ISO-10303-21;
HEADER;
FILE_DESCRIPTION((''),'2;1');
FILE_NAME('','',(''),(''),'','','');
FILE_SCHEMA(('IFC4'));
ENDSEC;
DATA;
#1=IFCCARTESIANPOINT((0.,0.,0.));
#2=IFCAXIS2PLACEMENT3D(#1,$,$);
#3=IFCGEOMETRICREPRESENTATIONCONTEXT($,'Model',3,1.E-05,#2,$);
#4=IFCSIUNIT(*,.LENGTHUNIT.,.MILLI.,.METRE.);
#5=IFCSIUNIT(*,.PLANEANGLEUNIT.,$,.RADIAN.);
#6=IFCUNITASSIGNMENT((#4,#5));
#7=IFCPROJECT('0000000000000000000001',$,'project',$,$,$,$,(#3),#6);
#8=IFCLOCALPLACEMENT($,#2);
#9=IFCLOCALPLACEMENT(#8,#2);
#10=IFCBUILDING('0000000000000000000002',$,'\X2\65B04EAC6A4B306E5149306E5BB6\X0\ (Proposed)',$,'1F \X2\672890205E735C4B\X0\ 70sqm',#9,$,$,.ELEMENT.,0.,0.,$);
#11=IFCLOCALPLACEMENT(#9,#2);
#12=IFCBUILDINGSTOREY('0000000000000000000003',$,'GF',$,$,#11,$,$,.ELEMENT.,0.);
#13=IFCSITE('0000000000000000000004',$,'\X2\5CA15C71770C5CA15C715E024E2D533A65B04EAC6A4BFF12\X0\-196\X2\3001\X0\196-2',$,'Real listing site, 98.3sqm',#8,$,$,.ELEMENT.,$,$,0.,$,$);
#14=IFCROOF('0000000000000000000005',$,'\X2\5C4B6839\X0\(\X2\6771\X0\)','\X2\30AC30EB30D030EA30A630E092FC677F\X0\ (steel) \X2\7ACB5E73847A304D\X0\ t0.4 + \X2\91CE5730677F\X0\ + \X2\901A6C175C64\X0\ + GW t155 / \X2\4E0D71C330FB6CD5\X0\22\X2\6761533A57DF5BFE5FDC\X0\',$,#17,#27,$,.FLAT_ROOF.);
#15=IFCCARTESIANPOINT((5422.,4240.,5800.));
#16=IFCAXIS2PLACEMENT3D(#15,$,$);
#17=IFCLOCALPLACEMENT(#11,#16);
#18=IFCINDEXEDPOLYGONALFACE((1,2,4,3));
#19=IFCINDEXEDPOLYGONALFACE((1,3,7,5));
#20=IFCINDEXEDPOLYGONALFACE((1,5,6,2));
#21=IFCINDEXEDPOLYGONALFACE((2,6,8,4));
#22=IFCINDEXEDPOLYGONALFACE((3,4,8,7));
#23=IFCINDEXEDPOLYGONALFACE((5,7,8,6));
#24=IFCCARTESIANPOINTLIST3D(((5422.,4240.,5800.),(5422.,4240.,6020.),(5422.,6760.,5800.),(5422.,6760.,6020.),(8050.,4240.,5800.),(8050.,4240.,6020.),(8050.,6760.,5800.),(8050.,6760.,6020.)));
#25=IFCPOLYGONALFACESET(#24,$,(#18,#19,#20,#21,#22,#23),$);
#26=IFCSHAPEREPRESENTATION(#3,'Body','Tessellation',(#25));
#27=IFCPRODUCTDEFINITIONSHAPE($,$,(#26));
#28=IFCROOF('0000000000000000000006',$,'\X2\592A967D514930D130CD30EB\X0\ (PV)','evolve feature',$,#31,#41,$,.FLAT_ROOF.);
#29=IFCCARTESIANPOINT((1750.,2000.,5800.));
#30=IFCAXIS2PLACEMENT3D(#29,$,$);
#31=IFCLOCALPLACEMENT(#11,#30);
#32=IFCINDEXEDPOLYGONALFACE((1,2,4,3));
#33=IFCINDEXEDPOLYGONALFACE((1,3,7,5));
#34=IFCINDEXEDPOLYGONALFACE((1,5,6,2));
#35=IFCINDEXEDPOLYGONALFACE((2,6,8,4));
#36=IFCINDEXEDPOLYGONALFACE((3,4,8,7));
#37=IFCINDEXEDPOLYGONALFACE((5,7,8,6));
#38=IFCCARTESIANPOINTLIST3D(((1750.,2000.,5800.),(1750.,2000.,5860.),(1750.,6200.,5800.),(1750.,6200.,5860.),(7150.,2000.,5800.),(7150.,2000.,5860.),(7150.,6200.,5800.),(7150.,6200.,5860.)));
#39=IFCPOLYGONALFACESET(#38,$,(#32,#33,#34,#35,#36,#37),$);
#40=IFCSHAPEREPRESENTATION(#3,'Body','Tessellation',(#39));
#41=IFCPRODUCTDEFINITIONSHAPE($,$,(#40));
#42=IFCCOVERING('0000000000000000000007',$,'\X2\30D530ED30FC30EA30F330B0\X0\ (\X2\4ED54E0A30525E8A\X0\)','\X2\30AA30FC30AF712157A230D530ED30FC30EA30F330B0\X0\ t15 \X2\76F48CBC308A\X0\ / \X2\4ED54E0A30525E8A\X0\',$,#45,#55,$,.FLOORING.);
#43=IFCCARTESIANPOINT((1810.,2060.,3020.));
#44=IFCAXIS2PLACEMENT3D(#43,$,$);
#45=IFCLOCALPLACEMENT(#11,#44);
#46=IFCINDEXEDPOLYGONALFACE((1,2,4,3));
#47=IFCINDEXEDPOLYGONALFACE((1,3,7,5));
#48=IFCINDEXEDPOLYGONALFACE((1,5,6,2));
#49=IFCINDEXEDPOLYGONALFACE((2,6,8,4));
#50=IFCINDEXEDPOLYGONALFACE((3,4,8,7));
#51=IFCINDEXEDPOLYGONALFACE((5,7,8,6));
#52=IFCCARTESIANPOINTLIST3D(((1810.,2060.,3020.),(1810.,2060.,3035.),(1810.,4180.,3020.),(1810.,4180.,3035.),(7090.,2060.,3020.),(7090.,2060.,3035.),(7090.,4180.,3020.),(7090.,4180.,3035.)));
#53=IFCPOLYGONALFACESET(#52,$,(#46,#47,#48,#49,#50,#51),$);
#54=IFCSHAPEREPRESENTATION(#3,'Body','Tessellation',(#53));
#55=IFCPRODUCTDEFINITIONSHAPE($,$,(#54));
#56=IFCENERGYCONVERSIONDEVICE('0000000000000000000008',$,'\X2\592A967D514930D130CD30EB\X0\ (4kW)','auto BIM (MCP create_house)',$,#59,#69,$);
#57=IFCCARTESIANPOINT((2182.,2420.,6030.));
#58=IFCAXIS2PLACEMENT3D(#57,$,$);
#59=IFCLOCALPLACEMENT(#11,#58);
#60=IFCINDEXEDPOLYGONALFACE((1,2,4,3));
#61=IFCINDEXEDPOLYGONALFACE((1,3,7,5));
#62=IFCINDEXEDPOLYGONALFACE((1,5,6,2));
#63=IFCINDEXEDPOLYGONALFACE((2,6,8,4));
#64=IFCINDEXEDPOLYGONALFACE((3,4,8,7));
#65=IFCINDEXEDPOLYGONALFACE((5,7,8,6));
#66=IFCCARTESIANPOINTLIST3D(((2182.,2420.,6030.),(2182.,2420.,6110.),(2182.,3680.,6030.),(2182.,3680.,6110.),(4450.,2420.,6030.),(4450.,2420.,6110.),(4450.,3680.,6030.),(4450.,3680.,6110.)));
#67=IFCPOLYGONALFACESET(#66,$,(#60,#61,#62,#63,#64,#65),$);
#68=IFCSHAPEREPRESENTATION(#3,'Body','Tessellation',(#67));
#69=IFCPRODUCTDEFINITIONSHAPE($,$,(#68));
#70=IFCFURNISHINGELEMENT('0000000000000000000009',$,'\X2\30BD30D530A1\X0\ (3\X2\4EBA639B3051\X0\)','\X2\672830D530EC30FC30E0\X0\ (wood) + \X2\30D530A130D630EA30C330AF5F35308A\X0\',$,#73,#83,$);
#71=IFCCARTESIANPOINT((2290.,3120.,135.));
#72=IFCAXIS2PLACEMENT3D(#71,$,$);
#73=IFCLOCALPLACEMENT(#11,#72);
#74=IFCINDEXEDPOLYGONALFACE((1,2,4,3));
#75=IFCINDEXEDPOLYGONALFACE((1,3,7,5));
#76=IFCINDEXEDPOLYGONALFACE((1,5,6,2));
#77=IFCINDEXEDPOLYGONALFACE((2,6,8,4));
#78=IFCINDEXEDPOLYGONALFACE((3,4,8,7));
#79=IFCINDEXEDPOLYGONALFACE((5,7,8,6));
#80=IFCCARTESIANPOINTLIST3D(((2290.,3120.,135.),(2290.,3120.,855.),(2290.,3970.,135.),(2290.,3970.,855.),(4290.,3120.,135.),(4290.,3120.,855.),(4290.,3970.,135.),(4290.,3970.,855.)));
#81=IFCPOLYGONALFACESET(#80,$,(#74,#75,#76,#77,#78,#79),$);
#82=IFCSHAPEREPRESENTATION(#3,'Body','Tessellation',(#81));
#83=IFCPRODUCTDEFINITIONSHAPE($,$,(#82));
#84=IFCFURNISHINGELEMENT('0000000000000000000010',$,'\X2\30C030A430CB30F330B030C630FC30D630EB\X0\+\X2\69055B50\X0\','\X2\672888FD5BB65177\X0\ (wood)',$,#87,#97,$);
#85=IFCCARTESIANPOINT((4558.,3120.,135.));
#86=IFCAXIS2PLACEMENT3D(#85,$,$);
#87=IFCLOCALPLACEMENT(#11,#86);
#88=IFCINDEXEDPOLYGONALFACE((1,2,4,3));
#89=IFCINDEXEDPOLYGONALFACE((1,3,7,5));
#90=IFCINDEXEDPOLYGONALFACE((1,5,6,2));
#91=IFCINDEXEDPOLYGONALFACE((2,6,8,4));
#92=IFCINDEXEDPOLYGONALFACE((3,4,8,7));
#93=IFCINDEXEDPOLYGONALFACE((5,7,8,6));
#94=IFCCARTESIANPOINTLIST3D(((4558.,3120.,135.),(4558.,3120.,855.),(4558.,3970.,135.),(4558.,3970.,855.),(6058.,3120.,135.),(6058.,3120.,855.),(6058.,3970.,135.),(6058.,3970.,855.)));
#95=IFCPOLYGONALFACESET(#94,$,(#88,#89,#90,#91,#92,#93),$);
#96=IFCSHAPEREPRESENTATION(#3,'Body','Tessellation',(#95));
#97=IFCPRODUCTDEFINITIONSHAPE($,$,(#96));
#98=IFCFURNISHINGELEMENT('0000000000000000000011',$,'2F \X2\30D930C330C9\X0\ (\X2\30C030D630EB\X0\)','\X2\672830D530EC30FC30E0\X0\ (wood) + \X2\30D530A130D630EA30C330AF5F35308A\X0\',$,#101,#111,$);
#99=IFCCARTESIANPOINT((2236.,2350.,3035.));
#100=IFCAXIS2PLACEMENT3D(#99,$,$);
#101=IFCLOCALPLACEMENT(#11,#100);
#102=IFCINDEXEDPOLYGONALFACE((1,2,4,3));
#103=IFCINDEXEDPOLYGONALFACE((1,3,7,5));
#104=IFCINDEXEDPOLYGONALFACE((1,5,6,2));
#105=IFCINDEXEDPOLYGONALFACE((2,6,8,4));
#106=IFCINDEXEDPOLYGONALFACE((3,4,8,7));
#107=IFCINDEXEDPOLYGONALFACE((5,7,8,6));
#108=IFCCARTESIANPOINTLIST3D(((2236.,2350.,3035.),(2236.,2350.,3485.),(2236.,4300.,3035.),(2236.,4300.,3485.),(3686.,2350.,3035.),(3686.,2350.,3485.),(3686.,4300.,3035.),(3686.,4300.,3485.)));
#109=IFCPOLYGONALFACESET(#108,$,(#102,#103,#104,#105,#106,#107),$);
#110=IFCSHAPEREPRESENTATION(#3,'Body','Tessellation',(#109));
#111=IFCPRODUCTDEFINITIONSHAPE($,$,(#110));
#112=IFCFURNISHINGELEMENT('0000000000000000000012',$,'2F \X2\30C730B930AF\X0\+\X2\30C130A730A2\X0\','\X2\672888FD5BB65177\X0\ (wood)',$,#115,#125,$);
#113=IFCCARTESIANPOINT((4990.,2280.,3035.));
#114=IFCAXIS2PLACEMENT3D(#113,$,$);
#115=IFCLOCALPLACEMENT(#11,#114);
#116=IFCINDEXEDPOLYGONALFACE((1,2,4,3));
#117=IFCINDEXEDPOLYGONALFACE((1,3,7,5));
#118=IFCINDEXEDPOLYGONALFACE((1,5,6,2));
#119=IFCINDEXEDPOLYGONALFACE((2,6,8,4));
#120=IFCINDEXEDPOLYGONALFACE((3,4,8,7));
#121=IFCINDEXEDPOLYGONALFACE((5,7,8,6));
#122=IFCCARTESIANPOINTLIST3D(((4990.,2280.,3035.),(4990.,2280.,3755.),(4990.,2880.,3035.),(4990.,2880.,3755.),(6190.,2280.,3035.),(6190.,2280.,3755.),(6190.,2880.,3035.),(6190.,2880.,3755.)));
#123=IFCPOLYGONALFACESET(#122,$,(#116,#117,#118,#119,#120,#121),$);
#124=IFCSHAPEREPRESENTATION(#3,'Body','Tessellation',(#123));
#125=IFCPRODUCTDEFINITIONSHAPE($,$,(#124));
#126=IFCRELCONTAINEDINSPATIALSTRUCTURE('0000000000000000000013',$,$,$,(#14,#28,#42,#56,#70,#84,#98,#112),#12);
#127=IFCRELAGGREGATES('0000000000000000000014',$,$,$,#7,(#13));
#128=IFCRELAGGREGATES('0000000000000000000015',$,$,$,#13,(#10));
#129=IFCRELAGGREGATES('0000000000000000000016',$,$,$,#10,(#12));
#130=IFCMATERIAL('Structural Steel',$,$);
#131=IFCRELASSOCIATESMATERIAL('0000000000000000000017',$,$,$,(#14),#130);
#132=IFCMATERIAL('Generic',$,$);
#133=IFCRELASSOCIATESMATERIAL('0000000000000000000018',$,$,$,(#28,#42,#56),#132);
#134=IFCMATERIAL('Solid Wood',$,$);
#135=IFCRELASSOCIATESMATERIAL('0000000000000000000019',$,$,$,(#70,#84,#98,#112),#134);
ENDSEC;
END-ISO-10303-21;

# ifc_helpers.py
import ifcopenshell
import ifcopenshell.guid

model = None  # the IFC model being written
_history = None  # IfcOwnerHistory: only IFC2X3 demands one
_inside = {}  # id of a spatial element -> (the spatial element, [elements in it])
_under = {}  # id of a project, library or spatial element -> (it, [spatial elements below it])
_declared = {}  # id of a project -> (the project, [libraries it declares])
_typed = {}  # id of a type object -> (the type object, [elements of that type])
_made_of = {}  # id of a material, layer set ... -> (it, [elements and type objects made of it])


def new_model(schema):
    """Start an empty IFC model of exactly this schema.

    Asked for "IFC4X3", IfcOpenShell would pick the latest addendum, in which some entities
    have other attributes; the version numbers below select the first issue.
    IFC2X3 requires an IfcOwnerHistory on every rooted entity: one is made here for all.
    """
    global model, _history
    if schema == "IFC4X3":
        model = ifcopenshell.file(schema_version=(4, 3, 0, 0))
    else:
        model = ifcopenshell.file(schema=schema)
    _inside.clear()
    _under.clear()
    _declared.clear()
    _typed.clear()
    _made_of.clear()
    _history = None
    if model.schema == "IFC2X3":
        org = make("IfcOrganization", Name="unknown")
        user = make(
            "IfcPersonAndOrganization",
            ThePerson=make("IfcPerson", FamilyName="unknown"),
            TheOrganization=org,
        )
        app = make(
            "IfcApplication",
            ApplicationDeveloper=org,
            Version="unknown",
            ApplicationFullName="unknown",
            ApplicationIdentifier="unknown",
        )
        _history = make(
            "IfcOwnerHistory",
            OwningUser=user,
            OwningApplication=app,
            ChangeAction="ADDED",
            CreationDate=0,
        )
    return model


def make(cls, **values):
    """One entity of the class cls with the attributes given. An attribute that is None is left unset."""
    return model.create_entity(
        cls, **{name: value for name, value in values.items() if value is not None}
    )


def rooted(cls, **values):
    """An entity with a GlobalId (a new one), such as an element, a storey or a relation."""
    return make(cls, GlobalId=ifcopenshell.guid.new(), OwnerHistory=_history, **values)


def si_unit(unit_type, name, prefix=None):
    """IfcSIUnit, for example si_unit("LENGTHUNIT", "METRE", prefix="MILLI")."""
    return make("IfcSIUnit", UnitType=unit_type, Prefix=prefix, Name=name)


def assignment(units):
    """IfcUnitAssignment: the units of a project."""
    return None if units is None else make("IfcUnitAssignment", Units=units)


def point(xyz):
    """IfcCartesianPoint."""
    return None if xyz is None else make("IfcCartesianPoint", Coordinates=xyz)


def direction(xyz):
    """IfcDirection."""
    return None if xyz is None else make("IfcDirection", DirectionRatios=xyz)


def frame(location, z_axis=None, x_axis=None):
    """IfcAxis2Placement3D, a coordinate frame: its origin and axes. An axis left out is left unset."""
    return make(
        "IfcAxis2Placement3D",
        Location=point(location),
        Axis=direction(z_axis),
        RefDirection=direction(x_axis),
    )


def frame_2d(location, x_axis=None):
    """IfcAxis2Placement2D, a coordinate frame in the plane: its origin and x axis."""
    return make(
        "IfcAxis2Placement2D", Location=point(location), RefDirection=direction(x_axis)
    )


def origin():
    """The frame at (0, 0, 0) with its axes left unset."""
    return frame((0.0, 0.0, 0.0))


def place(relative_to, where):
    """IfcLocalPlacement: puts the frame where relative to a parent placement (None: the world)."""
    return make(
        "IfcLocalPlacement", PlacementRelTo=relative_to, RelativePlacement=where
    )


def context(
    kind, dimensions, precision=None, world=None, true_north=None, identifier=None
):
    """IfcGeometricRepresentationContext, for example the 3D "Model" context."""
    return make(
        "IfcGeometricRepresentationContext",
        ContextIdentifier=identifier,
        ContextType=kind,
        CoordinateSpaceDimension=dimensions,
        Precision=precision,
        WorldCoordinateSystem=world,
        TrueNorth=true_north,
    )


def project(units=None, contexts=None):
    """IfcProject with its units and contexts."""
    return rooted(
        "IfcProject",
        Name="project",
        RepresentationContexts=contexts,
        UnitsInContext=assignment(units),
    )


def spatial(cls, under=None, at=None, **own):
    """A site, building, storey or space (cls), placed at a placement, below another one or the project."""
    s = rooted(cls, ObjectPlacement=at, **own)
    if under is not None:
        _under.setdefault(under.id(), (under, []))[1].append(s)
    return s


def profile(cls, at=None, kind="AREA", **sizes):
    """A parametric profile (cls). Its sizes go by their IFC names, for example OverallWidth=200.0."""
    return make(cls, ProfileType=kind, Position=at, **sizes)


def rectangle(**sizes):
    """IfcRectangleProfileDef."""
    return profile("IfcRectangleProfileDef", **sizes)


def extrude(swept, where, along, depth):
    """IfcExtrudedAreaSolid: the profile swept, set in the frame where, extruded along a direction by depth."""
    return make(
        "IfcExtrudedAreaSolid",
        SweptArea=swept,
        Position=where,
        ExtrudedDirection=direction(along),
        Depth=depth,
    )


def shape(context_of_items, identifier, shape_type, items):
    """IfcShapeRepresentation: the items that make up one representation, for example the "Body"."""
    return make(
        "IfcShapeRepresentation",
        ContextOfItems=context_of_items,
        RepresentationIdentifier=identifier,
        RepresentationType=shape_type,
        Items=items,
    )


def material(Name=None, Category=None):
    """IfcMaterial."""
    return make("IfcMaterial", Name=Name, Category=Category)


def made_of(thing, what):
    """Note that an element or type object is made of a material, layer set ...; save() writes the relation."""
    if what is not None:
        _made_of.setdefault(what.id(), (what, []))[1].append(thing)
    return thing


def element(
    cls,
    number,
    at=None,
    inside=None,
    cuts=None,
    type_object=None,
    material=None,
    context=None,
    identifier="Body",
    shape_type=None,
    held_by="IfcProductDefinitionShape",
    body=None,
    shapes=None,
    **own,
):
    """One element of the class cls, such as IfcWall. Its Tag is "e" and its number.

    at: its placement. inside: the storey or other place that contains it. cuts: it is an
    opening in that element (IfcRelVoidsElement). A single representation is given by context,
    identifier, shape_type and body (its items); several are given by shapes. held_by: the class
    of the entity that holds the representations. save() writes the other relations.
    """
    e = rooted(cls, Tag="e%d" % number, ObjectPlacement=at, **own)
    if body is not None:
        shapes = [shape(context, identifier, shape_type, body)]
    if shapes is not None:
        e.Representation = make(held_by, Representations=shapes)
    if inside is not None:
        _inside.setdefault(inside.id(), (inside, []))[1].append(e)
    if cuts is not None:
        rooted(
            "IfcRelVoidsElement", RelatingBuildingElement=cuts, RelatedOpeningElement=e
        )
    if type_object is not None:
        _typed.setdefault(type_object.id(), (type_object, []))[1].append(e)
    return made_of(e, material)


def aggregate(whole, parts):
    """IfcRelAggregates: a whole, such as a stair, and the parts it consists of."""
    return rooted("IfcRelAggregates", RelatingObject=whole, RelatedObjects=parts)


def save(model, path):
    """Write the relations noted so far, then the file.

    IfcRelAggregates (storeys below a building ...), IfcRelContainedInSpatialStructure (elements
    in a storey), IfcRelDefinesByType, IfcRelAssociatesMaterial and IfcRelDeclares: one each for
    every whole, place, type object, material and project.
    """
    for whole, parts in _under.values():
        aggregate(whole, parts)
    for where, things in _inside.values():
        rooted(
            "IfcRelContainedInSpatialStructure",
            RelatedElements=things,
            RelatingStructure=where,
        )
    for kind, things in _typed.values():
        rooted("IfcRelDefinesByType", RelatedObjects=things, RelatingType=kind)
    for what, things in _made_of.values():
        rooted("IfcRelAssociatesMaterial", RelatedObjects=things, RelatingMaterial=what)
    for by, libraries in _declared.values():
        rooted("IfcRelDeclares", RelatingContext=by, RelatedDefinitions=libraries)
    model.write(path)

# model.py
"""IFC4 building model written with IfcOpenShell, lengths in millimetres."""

from ifc_helpers import new_model, si_unit, frame, frame_2d, origin, place, context, project, spatial, rectangle, extrude, material, element, save


model = new_model("IFC4")

# Units and contexts
model_context = context("Model", 3, precision=1e-05, world=origin())
ifc_project = project(units=[si_unit("LENGTHUNIT", "METRE", prefix="MILLI"), si_unit("PLANEANGLEUNIT", "RADIAN")], contexts=[model_context])

# Site, building, storey
site_placement = place(None, origin())
site = spatial("IfcSite", under=ifc_project, at=site_placement, Name="岡山県岡山市中区新京橋２-196、196-2", ObjectType="Real listing site, 98.3sqm", CompositionType="ELEMENT", RefElevation=0.0)
building_placement = place(site_placement, origin())
building = spatial("IfcBuilding", under=site, at=building_placement, Name="新京橋の光の家 (Proposed)", ObjectType="1F 木造平屋 70sqm", CompositionType="ELEMENT", ElevationOfRefHeight=0.0, ElevationOfTerrain=0.0)
storey_placement = place(building_placement, origin())
storey = spatial("IfcBuildingStorey", under=building, at=storey_placement, Name="GF", CompositionType="ELEMENT", Elevation=0.0)

# Shared definitions
ifc_material_1 = material(Name="Solid Wood")

# Roofs
ifc_material_2 = material(Name="Structural Steel")
roof_1_placement = place(storey_placement, frame((5422.0, 4240.0, 5800.0)))
element("IfcRoof", 1, at=roof_1_placement, inside=storey, material=ifc_material_2, Name="屋根(東)", Description="ガルバリウム鋼板 (steel) 立平葺き t0.4 + 野地板 + 通気層 + GW t155 / 不燃・法22条区域対応", PredefinedType="FLAT_ROOF", context=model_context, shape_type="SweptSolid", body=[
    extrude(rectangle(XDim=2628.0, YDim=2520.0, at=frame_2d((1314.0, 1260.0))), frame((5422.0, 4240.0, 5800.0)), (0.0, 0.0, 1.0), 220.0),
])
ifc_material_3 = material(Name="Generic")
roof_2_placement = place(storey_placement, frame((1750.0, 2000.0, 5800.0)))
element("IfcRoof", 2, at=roof_2_placement, inside=storey, material=ifc_material_3, Name="太陽光パネル (PV)", Description="evolve feature", PredefinedType="FLAT_ROOF", context=model_context, shape_type="SweptSolid", body=[
    extrude(rectangle(XDim=5400.0, YDim=4200.0, at=frame_2d((2700.0, 2100.0))), frame((1750.0, 2000.0, 5800.0)), (0.0, 0.0, 1.0), 60.0),
])

# Covering
covering_placement = place(storey_placement, frame((1810.0, 2060.0, 3020.0)))
element("IfcCovering", 3, at=covering_placement, inside=storey, material=ifc_material_3, Name="フローリング (仕上げ床)", Description="オーク無垢フローリング t15 直貼り / 仕上げ床", PredefinedType="FLOORING", context=model_context, shape_type="SweptSolid", body=[
    extrude(rectangle(XDim=5280.0, YDim=2120.0, at=frame_2d((2640.0, 1060.0))), frame((1810.0, 2060.0, 3020.0)), (0.0, 0.0, 1.0), 15.0),
])

# Energy conversion device
energy_conversion_device_placement = place(storey_placement, frame((2182.0, 2420.0, 6030.0)))
element("IfcEnergyConversionDevice", 4, at=energy_conversion_device_placement, inside=storey, material=ifc_material_3, Name="太陽光パネル (4kW)", Description="auto BIM (MCP create_house)", context=model_context, shape_type="SweptSolid", body=[
    extrude(rectangle(XDim=2268.0, YDim=1260.0, at=frame_2d((1134.0, 630.0))), frame((2182.0, 2420.0, 6030.0)), (0.0, 0.0, 1.0), 80.0),
])

# Furnishing elements
furnishing_1_placement = place(storey_placement, frame((2290.0, 3120.0, 135.0)))
element("IfcFurnishingElement", 5, at=furnishing_1_placement, inside=storey, material=ifc_material_1, Name="ソファ (3人掛け)", Description="木フレーム (wood) + ファブリック張り", context=model_context, shape_type="SweptSolid", body=[
    extrude(rectangle(XDim=2000.0, YDim=850.0, at=frame_2d((1000.0, 425.0))), frame((2290.0, 3120.0, 135.0)), (0.0, 0.0, 1.0), 720.0),
])
furnishing_2_placement = place(storey_placement, frame((4558.0, 3120.0, 135.0)))
element("IfcFurnishingElement", 6, at=furnishing_2_placement, inside=storey, material=ifc_material_1, Name="ダイニングテーブル+椅子", Description="木製家具 (wood)", context=model_context, shape_type="SweptSolid", body=[
    extrude(rectangle(XDim=1500.0, YDim=850.0, at=frame_2d((750.0, 425.0))), frame((4558.0, 3120.0, 135.0)), (0.0, 0.0, 1.0), 720.0),
])
furnishing_3_placement = place(storey_placement, frame((2236.0, 2350.0, 3035.0)))
element("IfcFurnishingElement", 7, at=furnishing_3_placement, inside=storey, material=ifc_material_1, Name="2F ベッド (ダブル)", Description="木フレーム (wood) + ファブリック張り", context=model_context, shape_type="SweptSolid", body=[
    extrude(rectangle(XDim=1450.0, YDim=1950.0, at=frame_2d((725.0, 975.0))), frame((2236.0, 2350.0, 3035.0)), (0.0, 0.0, 1.0), 450.0),
])
furnishing_4_placement = place(storey_placement, frame((4990.0, 2280.0, 3035.0)))
element("IfcFurnishingElement", 8, at=furnishing_4_placement, inside=storey, material=ifc_material_1, Name="2F デスク+チェア", Description="木製家具 (wood)", context=model_context, shape_type="SweptSolid", body=[
    extrude(rectangle(XDim=1200.0, YDim=600.0, at=frame_2d((600.0, 300.0))), frame((4990.0, 2280.0, 3035.0)), (0.0, 0.0, 1.0), 720.0),
])

save(model, "model.ifc")
